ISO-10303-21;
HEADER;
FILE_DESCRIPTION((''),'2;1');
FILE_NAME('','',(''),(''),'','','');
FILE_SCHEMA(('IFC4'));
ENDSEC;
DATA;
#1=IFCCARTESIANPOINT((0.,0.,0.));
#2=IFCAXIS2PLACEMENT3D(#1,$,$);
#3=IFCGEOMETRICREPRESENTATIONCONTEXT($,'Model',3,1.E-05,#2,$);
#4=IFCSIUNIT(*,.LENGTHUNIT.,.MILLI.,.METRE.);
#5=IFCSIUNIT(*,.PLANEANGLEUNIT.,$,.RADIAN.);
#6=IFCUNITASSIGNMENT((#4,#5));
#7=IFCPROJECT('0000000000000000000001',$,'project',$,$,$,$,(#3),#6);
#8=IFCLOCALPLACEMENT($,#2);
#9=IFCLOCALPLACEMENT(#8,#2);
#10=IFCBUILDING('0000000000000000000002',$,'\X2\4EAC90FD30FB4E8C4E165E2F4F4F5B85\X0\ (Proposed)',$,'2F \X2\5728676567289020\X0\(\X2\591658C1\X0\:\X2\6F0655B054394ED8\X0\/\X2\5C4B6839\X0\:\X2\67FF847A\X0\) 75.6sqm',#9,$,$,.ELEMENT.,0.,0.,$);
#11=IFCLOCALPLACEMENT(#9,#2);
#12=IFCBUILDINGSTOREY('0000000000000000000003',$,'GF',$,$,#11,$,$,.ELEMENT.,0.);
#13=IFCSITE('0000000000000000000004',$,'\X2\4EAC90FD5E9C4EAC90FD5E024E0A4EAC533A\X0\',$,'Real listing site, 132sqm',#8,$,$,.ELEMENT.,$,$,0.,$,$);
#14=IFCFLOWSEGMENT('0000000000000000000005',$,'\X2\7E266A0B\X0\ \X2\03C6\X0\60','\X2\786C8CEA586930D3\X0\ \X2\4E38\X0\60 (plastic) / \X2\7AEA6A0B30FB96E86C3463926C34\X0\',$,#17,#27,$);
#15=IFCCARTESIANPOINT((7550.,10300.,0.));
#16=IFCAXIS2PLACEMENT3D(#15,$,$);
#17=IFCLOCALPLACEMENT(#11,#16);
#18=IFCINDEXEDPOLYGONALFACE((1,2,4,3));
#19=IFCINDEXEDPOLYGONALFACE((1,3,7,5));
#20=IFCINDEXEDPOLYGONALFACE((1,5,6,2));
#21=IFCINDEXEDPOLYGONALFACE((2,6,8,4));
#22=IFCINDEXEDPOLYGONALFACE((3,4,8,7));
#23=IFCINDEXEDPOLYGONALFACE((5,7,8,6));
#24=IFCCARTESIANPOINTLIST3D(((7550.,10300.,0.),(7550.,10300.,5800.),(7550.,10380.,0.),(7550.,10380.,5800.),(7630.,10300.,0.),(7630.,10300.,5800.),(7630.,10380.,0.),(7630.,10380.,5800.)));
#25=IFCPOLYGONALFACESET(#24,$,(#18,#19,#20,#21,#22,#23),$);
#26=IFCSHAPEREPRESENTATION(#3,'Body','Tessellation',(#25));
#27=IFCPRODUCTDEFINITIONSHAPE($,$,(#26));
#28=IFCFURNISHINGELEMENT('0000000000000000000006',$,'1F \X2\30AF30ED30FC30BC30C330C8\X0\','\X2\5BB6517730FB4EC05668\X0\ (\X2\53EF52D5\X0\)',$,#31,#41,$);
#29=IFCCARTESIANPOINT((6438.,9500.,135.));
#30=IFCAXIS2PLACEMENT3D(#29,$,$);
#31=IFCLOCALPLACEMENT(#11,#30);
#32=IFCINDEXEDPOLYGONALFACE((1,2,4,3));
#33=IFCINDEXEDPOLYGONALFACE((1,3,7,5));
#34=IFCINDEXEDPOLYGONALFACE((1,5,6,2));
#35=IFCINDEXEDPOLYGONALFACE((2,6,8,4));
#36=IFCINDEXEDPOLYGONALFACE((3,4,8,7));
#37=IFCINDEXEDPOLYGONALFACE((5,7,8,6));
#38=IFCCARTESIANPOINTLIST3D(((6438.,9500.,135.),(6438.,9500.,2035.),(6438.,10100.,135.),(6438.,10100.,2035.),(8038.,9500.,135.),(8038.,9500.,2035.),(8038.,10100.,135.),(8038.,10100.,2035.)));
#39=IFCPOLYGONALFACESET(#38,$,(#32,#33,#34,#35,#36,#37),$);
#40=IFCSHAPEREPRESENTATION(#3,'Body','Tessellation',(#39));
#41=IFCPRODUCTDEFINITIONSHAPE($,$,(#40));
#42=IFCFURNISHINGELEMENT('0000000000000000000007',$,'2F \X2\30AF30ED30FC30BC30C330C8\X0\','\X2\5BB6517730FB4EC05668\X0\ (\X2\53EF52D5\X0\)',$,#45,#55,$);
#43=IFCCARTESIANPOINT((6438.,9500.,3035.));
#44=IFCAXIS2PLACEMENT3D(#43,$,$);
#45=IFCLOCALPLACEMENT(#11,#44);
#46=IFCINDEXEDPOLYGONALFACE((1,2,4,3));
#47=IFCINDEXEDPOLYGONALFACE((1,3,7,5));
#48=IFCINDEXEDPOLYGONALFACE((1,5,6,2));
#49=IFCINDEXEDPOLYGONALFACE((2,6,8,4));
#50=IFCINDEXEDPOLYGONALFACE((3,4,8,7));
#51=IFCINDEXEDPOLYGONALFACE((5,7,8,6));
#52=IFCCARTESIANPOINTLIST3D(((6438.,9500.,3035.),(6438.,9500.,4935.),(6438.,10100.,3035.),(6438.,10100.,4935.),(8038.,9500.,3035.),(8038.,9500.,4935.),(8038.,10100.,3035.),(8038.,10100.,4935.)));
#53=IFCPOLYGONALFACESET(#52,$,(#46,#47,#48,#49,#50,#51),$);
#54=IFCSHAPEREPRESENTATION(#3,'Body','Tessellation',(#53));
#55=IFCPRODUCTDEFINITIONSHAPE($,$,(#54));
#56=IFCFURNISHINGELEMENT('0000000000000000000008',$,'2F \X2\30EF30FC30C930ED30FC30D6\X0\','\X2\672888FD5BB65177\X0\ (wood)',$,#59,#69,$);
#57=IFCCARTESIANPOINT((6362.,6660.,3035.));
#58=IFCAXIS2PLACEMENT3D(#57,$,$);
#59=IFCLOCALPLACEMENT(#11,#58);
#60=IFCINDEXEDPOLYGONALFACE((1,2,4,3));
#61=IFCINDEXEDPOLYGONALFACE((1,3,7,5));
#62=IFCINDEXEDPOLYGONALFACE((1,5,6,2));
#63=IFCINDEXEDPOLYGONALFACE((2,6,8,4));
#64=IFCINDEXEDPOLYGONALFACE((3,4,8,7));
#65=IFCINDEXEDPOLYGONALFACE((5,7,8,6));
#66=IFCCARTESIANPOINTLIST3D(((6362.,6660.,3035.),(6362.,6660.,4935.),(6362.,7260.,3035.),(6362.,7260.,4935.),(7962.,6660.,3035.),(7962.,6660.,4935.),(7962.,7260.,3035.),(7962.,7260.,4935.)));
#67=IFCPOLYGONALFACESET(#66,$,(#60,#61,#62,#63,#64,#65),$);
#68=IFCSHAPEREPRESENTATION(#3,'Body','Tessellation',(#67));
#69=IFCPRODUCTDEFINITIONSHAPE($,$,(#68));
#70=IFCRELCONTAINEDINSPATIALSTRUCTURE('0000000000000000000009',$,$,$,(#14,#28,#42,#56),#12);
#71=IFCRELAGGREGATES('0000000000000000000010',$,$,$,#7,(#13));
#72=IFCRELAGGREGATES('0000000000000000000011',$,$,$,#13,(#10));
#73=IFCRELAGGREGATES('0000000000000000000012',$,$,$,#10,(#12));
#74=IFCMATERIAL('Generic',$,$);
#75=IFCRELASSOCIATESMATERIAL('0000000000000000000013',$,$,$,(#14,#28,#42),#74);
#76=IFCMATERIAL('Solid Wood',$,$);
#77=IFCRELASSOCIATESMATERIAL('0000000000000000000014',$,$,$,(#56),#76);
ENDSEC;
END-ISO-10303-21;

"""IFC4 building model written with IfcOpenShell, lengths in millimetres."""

from ifc_helpers import new_model, si_unit, frame, frame_2d, origin, place, context, project, spatial, rectangle, extrude, material, element, save


model = new_model("IFC4")

# Units and contexts
model_context = context("Model", 3, precision=1e-05, world=origin())
ifc_project = project(units=[si_unit("LENGTHUNIT", "METRE", prefix="MILLI"), si_unit("PLANEANGLEUNIT", "RADIAN")], contexts=[model_context])

# Site, building, storey
site_placement = place(None, origin())
site = spatial("IfcSite", under=ifc_project, at=site_placement, Name="京都府京都市上京区", ObjectType="Real listing site, 132sqm", CompositionType="ELEMENT", RefElevation=0.0)
building_placement = place(site_placement, origin())
building = spatial("IfcBuilding", under=site, at=building_placement, Name="京都・二世帯住宅 (Proposed)", ObjectType="2F 在来木造(外壁:漆喰吹付/屋根:柿葺) 75.6sqm", CompositionType="ELEMENT", ElevationOfRefHeight=0.0, ElevationOfTerrain=0.0)
storey_placement = place(building_placement, origin())
storey = spatial("IfcBuildingStorey", under=building, at=storey_placement, Name="GF", CompositionType="ELEMENT", Elevation=0.0)

# Shared definitions
ifc_material_1 = material(Name="Solid Wood")

# Shared definitions
ifc_material_2 = material(Name="Generic")

# Flow segment
flow_segment_placement = place(storey_placement, frame((7550.0, 10300.0, 0.0)))
element("IfcFlowSegment", 1, at=flow_segment_placement, inside=storey, material=ifc_material_2, Name="縦樋 φ60", Description="硬質塩ビ 丸60 (plastic) / 竪樋・雨水排水", context=model_context, shape_type="SweptSolid", body=[
    extrude(rectangle(XDim=80.0, YDim=80.0, at=frame_2d((40.0, 40.0))), frame((7550.0, 10300.0, 0.0)), (0.0, 0.0, 1.0), 5800.0),
])

# Furnishing elements
furnishing_1_placement = place(storey_placement, frame((6438.0, 9500.0, 135.0)))
element("IfcFurnishingElement", 2, at=furnishing_1_placement, inside=storey, material=ifc_material_2, Name="1F クローゼット", Description="家具・什器 (可動)", context=model_context, shape_type="SweptSolid", body=[
    extrude(rectangle(XDim=1600.0, YDim=600.0, at=frame_2d((800.0, 300.0))), frame((6438.0, 9500.0, 135.0)), (0.0, 0.0, 1.0), 1900.0),
])
furnishing_2_placement = place(storey_placement, frame((6438.0, 9500.0, 3035.0)))
element("IfcFurnishingElement", 3, at=furnishing_2_placement, inside=storey, material=ifc_material_2, Name="2F クローゼット", Description="家具・什器 (可動)", context=model_context, shape_type="SweptSolid", body=[
    extrude(rectangle(XDim=1600.0, YDim=600.0, at=frame_2d((800.0, 300.0))), frame((6438.0, 9500.0, 3035.0)), (0.0, 0.0, 1.0), 1900.0),
])
furnishing_3_placement = place(storey_placement, frame((6362.0, 6660.0, 3035.0)))
element("IfcFurnishingElement", 4, at=furnishing_3_placement, inside=storey, material=ifc_material_1, Name="2F ワードローブ", Description="木製家具 (wood)", context=model_context, shape_type="SweptSolid", body=[
    extrude(rectangle(XDim=1600.0, YDim=600.0, at=frame_2d((800.0, 300.0))), frame((6362.0, 6660.0, 3035.0)), (0.0, 0.0, 1.0), 1900.0),
])

save(model, "model.ifc")
